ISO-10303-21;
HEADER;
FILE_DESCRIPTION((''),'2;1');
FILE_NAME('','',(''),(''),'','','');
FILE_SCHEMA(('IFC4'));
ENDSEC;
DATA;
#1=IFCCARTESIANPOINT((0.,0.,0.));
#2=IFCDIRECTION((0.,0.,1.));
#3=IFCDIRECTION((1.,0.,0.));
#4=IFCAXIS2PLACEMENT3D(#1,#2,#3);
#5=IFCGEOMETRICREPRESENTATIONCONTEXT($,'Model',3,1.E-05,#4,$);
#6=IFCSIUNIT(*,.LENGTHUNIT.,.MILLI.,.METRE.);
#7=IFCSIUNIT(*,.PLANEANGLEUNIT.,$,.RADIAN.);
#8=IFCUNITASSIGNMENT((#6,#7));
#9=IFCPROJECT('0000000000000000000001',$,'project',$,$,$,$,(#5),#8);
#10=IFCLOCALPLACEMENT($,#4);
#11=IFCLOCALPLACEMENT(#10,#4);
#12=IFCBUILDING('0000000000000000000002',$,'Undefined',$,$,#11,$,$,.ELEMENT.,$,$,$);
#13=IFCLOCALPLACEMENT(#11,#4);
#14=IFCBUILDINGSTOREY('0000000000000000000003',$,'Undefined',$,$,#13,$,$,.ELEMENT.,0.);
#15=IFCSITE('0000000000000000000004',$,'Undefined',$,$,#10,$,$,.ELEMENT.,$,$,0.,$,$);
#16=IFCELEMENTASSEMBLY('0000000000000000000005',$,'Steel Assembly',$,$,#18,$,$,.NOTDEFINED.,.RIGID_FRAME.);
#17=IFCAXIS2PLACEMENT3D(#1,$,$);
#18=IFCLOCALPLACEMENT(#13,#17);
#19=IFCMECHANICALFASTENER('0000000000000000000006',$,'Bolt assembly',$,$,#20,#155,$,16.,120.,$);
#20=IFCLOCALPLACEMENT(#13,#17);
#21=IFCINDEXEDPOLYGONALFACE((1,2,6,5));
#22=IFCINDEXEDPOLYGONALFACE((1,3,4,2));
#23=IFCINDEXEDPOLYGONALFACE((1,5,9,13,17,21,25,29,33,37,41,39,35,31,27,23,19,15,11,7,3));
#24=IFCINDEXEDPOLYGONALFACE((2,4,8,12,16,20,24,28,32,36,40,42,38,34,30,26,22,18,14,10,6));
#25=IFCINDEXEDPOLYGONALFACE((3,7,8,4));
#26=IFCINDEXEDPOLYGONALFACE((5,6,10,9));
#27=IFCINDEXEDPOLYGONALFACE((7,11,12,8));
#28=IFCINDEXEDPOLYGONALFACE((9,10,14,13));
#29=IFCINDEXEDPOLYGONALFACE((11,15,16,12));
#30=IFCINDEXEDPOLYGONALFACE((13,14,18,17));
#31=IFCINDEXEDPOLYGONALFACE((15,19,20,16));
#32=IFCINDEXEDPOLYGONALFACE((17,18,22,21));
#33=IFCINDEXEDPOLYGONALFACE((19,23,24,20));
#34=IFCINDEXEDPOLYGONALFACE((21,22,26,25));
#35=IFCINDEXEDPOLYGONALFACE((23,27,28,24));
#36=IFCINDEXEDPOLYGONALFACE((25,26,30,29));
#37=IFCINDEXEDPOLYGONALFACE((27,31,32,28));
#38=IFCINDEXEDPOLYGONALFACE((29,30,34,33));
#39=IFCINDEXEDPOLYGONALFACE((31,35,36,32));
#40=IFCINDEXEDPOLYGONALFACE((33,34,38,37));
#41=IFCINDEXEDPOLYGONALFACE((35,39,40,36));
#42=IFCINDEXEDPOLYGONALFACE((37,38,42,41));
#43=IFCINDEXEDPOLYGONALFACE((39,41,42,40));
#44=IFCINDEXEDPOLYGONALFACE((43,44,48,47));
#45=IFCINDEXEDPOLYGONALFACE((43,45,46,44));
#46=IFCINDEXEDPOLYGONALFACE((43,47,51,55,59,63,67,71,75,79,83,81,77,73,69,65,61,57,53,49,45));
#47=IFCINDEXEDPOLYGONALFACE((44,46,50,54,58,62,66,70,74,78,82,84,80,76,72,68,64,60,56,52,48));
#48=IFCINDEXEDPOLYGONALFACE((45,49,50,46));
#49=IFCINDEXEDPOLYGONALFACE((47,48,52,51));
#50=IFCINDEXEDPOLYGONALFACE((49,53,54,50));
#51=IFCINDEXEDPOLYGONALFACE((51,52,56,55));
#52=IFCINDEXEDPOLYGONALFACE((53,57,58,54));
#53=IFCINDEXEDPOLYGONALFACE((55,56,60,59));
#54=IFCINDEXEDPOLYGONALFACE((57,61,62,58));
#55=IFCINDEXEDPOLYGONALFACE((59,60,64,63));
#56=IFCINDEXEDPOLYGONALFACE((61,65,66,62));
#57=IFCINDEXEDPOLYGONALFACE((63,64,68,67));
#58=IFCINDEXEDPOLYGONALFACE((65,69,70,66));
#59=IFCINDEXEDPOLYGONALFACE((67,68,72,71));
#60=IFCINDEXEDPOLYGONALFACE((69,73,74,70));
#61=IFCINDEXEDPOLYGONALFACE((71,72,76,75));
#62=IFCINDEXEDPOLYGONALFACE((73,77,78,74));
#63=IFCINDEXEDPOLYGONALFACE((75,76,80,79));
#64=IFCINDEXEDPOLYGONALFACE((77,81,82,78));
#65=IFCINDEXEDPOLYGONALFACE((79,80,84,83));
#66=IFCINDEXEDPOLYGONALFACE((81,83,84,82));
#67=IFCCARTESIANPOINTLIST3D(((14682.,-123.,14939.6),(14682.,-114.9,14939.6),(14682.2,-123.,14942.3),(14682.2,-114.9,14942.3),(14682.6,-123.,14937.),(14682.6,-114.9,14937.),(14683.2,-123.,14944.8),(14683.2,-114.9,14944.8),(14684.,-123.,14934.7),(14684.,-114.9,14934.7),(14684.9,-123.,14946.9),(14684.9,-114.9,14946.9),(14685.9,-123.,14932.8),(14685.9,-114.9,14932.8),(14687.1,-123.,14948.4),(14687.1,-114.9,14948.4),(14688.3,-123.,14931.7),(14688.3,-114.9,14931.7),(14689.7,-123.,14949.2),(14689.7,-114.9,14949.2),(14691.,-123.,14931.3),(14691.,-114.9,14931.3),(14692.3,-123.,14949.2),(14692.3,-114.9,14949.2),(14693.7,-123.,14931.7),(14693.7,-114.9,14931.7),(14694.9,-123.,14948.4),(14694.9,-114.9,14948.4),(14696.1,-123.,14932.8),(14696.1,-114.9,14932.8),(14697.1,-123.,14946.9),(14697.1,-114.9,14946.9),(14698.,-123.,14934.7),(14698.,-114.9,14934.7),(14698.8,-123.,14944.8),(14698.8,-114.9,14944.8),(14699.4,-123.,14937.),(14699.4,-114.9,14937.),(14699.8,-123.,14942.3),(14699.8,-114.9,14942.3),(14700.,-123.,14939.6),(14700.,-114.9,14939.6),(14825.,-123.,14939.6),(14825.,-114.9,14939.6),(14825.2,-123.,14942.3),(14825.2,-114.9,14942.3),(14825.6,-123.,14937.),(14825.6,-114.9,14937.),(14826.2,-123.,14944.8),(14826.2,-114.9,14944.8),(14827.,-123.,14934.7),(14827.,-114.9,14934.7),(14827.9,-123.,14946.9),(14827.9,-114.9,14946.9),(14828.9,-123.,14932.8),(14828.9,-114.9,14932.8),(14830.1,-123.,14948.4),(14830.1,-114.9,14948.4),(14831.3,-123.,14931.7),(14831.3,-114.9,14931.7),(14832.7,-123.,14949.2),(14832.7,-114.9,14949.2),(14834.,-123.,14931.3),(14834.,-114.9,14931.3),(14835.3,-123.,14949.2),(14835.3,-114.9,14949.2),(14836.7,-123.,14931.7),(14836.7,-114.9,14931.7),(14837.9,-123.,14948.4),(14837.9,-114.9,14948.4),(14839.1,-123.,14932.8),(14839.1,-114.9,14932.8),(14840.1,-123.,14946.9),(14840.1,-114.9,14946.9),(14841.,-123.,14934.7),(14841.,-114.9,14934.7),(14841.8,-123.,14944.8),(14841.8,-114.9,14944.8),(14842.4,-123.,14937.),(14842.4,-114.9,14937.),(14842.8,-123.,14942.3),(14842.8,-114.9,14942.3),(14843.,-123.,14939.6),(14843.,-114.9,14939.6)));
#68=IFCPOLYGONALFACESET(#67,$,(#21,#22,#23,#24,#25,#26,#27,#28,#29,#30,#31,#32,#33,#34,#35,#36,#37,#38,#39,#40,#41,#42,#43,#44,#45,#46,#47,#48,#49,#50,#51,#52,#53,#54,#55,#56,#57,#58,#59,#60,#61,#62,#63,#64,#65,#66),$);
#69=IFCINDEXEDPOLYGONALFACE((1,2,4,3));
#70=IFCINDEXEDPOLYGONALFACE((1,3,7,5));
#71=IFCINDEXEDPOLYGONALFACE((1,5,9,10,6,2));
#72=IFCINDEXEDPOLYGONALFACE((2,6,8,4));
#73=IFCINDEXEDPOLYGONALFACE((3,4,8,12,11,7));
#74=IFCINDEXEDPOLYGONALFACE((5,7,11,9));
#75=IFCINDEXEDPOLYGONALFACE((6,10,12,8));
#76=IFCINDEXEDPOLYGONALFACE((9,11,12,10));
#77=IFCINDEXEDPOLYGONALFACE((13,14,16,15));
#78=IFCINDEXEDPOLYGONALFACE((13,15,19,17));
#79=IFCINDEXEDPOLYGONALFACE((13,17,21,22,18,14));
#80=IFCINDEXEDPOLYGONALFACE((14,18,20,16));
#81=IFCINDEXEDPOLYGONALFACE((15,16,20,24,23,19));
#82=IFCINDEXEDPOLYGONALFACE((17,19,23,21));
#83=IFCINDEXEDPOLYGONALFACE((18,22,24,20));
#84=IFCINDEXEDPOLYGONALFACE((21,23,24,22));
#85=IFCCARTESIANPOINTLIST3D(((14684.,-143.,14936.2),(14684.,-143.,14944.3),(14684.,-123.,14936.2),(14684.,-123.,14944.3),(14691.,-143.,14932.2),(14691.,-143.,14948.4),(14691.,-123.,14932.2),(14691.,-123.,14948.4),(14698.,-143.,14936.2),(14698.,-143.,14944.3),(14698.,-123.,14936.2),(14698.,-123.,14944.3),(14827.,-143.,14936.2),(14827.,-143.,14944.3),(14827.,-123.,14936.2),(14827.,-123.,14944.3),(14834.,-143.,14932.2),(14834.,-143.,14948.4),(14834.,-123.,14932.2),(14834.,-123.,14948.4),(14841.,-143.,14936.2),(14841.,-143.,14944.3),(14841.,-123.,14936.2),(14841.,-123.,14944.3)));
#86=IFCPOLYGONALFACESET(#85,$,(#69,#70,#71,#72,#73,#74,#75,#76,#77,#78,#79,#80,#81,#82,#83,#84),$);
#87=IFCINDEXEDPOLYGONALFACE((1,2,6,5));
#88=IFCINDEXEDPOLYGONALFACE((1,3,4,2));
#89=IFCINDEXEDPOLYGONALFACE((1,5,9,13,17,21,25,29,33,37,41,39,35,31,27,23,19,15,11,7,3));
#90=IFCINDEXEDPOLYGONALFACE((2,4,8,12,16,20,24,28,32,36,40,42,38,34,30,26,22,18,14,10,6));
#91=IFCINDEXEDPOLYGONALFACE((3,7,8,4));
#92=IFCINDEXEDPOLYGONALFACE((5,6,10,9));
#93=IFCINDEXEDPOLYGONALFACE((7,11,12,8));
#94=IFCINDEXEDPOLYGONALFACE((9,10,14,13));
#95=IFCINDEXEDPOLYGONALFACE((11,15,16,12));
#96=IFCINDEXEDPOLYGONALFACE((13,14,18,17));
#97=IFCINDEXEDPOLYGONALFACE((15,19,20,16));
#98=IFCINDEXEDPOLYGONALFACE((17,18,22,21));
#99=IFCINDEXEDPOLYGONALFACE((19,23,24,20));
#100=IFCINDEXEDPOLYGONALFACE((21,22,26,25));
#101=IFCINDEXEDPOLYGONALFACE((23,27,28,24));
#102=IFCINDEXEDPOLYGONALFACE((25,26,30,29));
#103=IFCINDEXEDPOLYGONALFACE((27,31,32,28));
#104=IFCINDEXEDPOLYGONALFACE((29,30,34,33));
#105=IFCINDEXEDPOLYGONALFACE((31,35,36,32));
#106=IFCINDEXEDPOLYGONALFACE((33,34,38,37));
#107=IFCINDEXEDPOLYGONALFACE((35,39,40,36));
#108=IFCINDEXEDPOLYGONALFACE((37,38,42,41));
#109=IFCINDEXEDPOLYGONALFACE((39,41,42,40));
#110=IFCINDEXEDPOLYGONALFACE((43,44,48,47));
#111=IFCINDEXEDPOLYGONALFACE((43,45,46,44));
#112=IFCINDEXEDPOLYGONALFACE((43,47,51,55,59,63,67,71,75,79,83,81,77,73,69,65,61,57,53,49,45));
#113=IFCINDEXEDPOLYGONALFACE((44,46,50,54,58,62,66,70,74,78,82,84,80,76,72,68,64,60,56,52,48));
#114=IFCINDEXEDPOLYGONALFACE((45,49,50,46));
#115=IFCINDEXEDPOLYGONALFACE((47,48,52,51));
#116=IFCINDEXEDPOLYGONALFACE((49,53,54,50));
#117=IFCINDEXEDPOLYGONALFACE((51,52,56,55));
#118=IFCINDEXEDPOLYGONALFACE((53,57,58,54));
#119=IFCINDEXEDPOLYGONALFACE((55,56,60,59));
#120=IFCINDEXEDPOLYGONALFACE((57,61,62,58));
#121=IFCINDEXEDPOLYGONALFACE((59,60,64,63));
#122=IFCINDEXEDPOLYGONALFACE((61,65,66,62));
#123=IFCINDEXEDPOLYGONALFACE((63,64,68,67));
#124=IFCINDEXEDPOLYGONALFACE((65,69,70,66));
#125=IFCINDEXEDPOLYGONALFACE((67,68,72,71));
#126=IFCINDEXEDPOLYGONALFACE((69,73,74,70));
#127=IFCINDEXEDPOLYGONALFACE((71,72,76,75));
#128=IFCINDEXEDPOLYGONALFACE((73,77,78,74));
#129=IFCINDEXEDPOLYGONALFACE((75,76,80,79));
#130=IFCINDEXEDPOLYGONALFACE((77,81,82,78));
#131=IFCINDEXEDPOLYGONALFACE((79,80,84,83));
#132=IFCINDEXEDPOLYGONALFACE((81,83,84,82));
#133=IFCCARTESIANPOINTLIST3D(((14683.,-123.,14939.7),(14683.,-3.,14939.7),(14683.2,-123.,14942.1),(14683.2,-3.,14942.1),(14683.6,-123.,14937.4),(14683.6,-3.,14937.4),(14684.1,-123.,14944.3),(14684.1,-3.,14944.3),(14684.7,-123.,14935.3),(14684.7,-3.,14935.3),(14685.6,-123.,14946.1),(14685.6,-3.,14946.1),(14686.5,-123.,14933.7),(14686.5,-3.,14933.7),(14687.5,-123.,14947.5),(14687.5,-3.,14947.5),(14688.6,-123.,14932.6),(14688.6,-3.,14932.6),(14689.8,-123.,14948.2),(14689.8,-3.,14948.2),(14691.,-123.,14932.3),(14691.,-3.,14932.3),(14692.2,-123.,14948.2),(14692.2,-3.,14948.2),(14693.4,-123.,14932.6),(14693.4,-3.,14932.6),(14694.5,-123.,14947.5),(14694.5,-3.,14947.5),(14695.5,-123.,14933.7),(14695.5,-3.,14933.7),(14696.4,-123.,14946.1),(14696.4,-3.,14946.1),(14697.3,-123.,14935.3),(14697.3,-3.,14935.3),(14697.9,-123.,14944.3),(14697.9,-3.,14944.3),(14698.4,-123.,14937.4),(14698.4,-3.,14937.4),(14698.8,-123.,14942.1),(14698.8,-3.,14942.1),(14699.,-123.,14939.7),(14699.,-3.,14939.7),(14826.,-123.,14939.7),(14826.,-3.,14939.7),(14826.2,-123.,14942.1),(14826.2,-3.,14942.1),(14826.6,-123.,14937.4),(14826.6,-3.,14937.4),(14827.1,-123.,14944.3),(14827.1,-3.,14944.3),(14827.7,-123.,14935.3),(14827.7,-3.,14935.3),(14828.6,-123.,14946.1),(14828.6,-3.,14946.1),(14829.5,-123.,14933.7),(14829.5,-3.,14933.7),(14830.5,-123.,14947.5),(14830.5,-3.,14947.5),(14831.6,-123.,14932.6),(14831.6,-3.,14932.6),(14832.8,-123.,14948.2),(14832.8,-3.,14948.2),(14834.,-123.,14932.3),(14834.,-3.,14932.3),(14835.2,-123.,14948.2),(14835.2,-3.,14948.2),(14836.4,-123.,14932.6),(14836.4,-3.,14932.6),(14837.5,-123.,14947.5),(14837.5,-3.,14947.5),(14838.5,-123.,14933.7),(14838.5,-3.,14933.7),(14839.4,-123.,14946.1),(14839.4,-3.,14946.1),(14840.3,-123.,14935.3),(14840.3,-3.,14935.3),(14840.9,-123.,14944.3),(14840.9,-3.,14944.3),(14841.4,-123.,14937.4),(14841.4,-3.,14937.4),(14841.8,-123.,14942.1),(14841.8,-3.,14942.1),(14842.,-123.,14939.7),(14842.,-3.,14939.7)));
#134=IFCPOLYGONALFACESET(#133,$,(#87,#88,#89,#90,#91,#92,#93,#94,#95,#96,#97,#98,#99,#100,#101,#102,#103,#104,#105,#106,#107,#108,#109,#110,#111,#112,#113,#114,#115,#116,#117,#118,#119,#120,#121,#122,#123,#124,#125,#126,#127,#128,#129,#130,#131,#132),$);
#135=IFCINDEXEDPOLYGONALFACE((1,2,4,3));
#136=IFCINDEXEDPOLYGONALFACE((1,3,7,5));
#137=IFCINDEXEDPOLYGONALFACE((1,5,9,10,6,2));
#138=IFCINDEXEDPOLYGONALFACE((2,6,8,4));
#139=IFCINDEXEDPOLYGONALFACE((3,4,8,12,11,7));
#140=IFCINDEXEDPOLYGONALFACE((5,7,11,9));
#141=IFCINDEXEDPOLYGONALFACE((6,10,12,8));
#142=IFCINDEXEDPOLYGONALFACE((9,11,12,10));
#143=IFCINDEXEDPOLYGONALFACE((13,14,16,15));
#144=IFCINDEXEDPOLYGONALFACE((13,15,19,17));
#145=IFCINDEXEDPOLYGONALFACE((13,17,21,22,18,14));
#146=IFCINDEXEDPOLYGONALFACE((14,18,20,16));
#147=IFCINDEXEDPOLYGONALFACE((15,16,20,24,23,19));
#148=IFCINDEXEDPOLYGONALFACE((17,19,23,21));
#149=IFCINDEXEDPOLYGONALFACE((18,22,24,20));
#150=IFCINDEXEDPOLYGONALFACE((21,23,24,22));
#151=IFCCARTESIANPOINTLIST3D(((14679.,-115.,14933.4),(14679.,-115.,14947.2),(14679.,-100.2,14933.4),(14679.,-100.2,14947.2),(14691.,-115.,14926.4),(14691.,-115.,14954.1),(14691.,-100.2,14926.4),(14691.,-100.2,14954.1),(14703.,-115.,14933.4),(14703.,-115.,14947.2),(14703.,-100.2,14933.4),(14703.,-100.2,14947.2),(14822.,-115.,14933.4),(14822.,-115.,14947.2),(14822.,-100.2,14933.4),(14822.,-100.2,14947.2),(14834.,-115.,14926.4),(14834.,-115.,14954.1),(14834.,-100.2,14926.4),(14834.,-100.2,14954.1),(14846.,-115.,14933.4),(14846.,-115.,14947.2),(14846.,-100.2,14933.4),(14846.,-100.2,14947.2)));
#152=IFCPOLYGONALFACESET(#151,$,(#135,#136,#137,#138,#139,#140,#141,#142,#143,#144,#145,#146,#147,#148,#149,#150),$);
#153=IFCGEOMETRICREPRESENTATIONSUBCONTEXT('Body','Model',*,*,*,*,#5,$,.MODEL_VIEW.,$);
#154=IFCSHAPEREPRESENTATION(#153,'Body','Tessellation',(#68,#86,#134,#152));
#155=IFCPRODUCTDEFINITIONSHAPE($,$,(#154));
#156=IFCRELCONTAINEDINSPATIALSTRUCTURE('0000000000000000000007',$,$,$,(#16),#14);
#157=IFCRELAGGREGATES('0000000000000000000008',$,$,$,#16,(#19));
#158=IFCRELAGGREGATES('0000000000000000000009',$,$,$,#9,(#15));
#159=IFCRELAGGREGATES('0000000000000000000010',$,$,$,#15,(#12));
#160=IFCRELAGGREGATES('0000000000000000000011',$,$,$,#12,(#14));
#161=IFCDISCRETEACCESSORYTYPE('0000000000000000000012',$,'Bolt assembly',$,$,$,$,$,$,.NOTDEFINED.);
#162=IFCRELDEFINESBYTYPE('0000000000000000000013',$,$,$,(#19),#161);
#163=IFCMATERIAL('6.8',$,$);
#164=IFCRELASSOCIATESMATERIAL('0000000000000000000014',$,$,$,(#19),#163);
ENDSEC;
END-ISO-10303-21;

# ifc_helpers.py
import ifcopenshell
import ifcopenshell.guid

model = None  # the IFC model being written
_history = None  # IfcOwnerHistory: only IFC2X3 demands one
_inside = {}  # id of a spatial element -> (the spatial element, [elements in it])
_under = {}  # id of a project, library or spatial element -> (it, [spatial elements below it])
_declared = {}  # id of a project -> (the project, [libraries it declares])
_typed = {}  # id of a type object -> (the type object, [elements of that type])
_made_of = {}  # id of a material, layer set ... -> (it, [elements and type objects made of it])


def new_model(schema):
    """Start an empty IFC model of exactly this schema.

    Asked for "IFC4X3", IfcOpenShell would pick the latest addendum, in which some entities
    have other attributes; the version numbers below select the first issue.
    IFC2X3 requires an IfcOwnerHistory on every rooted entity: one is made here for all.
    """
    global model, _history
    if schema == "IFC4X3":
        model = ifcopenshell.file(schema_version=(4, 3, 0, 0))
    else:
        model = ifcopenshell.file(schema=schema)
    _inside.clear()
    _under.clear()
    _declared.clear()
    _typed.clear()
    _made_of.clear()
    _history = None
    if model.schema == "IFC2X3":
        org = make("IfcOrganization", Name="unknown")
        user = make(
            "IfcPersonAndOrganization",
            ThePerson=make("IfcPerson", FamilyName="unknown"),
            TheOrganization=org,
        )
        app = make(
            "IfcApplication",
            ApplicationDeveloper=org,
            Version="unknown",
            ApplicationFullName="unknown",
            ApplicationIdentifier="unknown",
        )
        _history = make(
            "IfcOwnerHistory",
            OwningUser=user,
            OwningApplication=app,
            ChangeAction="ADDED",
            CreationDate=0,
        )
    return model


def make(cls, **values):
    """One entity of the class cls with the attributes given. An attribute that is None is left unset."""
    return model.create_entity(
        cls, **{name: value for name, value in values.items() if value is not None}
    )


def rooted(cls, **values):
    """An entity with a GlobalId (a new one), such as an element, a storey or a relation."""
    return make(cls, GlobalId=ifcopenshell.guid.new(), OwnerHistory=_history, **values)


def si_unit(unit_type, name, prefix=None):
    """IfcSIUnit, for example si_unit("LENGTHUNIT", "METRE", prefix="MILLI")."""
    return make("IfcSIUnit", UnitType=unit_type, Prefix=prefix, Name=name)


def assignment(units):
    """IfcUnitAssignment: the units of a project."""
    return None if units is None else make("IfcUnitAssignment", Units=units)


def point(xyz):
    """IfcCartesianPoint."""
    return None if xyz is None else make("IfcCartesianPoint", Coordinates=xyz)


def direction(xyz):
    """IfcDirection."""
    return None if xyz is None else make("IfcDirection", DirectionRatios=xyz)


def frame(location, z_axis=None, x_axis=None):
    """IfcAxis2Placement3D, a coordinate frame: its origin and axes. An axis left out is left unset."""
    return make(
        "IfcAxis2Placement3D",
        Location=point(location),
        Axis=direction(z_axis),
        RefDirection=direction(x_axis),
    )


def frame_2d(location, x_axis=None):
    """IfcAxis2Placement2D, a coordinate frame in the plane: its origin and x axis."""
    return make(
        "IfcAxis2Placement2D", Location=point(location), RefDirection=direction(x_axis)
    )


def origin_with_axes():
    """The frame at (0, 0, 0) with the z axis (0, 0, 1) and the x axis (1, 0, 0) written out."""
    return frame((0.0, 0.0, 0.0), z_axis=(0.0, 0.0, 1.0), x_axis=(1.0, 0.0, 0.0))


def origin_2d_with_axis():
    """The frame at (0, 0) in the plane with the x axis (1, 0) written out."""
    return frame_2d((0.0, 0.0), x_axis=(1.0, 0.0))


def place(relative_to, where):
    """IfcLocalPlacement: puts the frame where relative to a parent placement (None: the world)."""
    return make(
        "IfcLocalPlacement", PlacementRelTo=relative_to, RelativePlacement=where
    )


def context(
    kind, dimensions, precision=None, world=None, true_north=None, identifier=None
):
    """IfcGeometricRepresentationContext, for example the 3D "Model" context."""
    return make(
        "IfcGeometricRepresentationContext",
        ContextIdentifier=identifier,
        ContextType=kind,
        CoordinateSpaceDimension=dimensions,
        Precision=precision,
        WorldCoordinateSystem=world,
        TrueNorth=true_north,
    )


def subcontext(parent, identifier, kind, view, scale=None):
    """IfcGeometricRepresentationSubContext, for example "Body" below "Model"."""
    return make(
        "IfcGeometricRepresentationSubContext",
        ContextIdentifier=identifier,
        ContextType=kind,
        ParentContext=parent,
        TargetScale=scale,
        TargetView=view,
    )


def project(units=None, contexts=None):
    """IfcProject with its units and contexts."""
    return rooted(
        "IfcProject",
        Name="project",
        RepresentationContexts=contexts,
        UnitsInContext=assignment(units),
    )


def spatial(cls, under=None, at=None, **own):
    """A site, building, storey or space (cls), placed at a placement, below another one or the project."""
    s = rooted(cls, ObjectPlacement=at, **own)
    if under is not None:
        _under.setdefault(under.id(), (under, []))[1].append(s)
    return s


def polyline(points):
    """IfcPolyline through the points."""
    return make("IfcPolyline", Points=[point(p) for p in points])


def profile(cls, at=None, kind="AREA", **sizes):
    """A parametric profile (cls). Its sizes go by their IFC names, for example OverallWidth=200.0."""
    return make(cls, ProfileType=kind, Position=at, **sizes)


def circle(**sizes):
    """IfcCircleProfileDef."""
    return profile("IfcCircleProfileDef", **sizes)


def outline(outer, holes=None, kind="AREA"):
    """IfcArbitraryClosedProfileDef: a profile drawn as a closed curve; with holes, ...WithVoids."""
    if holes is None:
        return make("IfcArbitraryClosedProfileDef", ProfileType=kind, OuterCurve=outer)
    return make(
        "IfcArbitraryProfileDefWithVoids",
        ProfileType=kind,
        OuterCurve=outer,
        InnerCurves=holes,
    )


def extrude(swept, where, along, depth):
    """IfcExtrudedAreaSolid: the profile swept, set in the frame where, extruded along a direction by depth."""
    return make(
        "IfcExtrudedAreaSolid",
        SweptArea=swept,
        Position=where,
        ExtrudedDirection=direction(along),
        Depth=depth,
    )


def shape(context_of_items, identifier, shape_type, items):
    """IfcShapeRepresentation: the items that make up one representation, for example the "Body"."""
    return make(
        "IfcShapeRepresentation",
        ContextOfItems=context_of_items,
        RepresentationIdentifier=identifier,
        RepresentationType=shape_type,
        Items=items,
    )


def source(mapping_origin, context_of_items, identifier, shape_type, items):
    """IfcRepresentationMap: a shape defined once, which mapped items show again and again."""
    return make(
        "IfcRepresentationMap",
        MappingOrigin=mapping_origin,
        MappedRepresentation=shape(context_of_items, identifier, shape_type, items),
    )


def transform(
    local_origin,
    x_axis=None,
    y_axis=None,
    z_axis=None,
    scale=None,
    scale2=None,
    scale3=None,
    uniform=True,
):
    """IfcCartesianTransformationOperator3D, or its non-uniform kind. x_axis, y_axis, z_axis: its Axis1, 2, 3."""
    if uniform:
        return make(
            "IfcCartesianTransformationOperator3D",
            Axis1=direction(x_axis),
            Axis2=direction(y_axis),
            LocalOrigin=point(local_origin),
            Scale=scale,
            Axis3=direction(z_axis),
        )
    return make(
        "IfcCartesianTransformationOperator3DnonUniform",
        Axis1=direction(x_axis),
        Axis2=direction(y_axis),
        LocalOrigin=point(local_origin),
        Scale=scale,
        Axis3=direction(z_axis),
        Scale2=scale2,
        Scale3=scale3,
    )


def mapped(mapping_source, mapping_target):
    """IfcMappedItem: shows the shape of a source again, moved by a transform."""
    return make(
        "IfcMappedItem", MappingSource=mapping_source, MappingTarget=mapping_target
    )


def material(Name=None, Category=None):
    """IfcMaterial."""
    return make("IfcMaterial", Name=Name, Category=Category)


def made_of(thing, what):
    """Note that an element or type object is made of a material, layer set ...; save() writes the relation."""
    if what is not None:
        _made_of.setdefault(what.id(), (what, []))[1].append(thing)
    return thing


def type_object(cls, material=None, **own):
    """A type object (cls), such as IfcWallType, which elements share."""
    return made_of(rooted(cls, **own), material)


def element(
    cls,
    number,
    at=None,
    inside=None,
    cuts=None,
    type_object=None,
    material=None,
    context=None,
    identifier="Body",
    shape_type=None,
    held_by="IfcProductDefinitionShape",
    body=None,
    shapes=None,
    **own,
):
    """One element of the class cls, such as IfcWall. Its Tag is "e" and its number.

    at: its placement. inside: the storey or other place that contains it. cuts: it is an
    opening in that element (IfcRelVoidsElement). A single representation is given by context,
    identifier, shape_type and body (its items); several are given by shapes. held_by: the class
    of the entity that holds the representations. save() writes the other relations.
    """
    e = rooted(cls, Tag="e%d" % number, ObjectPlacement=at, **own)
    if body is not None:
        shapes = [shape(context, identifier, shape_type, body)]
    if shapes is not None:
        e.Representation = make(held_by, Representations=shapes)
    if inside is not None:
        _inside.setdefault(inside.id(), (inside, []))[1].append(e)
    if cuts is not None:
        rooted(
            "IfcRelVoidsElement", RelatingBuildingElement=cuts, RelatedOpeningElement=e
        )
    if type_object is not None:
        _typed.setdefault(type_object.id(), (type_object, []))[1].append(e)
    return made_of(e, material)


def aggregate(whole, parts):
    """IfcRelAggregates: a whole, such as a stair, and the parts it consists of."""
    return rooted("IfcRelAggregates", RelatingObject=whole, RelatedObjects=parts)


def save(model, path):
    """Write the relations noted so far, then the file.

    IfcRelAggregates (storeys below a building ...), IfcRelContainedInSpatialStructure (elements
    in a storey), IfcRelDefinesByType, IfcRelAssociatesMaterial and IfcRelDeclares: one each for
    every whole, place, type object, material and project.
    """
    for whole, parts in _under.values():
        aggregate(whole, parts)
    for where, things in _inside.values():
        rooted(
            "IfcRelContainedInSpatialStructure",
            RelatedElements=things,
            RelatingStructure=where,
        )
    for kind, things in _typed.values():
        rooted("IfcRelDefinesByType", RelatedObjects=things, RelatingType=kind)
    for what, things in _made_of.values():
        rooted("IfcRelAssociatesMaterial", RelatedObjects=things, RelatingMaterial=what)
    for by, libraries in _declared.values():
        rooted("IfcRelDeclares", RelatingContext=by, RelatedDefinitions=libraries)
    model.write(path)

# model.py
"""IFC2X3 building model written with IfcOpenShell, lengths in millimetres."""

from ifc_helpers import new_model, si_unit, frame, origin_with_axes, origin_2d_with_axis, place, context, subcontext, project, spatial, polyline, circle, outline, extrude, source, transform, mapped, material, type_object, element, aggregate, save


model = new_model("IFC2X3")

# Units and contexts
model_context = context("Model", 3, precision=1e-05, world=origin_with_axes())
body_context = subcontext(model_context, "Body", "Model", "MODEL_VIEW")
ifc_project = project(units=[si_unit("LENGTHUNIT", "METRE", prefix="MILLI"), si_unit("PLANEANGLEUNIT", "RADIAN")], contexts=[model_context])

# Site, building, storey
site_placement = place(None, origin_with_axes())
site = spatial("IfcSite", under=ifc_project, at=site_placement, Name="Undefined", CompositionType="ELEMENT", RefElevation=0.0)
building_placement = place(site_placement, origin_with_axes())
building = spatial("IfcBuilding", under=site, at=building_placement, Name="Undefined", CompositionType="ELEMENT")
storey_placement = place(building_placement, origin_with_axes())
storey = spatial("IfcBuildingStorey", under=building, at=storey_placement, Name="Undefined", CompositionType="ELEMENT", Elevation=0.0)

# Element assembly
assembly_1_placement = place(storey_placement, origin_with_axes())
assembly_1 = element("IfcElementAssembly", 1, at=assembly_1_placement, inside=storey, Name="Steel Assembly", AssemblyPlace="NOTDEFINED", PredefinedType="RIGID_FRAME")

# Shared definitions
discrete_accessory_type_1 = type_object("IfcDiscreteAccessoryType", Name="Bolt assembly")

# Mechanical fastener
ifc_material_1 = material(Name="6.8")
shared_shape_1 = source(origin_with_axes(), body_context, "Body", "SweptSolid", [
    extrude(circle(Radius=9.0, at=origin_2d_with_axis()), frame((0.0, 0.0, 0.0), z_axis=(0.0, 1.0, 0.0), x_axis=(1.0, 0.0, 0.0)), (0.0, 0.0, 1.0), 8.1),
    extrude(outline(polyline([(8.1, 0.0), (4.0, 7.0), (-4.0, 7.0), (-8.1, 0.0), (-4.0, -7.0), (4.0, -7.0), (8.1, 0.0)])), frame((0.0, -20.0, 0.0), z_axis=(0.0, 1.0, 0.0), x_axis=(1.0, 0.0, 0.0)), (0.0, 0.0, 1.0), 20.0),
    extrude(circle(Radius=8.0, at=origin_2d_with_axis()), frame((0.0, 0.0, 0.0), z_axis=(0.0, 1.0, 0.0), x_axis=(1.0, 0.0, 0.0)), (0.0, 0.0, 1.0), 120.0),
    extrude(outline(polyline([(13.9, 0.0), (6.9, 12.0), (-6.9, 12.0), (-13.9, 0.0), (-6.9, -12.0), (6.9, -12.0), (13.9, 0.0)])), frame((0.0, 8.0, 0.0), z_axis=(0.0, 1.0, 0.0), x_axis=(1.0, 0.0, 0.0)), (0.0, 0.0, 1.0), 14.8),
])
mechanical_fastener_1_placement = place(assembly_1_placement, frame((14762.5, -123.0, 14990.8), z_axis=(1.0, 0.0, 0.0), x_axis=(0.0, 0.0, -1.0)))
mechanical_fastener_1 = element("IfcMechanicalFastener", 2, at=mechanical_fastener_1_placement, type_object=discrete_accessory_type_1, material=ifc_material_1, Name="Bolt assembly", NominalDiameter=16.0, NominalLength=120.0, context=body_context, shape_type="MappedRepresentation", body=[
    mapped(shared_shape_1, transform((50.5, 0.0, -71.5))),
    mapped(shared_shape_1, transform((50.5, 0.0, 71.5))),
])
aggregate(assembly_1, [mechanical_fastener_1])

save(model, "model.ifc")
